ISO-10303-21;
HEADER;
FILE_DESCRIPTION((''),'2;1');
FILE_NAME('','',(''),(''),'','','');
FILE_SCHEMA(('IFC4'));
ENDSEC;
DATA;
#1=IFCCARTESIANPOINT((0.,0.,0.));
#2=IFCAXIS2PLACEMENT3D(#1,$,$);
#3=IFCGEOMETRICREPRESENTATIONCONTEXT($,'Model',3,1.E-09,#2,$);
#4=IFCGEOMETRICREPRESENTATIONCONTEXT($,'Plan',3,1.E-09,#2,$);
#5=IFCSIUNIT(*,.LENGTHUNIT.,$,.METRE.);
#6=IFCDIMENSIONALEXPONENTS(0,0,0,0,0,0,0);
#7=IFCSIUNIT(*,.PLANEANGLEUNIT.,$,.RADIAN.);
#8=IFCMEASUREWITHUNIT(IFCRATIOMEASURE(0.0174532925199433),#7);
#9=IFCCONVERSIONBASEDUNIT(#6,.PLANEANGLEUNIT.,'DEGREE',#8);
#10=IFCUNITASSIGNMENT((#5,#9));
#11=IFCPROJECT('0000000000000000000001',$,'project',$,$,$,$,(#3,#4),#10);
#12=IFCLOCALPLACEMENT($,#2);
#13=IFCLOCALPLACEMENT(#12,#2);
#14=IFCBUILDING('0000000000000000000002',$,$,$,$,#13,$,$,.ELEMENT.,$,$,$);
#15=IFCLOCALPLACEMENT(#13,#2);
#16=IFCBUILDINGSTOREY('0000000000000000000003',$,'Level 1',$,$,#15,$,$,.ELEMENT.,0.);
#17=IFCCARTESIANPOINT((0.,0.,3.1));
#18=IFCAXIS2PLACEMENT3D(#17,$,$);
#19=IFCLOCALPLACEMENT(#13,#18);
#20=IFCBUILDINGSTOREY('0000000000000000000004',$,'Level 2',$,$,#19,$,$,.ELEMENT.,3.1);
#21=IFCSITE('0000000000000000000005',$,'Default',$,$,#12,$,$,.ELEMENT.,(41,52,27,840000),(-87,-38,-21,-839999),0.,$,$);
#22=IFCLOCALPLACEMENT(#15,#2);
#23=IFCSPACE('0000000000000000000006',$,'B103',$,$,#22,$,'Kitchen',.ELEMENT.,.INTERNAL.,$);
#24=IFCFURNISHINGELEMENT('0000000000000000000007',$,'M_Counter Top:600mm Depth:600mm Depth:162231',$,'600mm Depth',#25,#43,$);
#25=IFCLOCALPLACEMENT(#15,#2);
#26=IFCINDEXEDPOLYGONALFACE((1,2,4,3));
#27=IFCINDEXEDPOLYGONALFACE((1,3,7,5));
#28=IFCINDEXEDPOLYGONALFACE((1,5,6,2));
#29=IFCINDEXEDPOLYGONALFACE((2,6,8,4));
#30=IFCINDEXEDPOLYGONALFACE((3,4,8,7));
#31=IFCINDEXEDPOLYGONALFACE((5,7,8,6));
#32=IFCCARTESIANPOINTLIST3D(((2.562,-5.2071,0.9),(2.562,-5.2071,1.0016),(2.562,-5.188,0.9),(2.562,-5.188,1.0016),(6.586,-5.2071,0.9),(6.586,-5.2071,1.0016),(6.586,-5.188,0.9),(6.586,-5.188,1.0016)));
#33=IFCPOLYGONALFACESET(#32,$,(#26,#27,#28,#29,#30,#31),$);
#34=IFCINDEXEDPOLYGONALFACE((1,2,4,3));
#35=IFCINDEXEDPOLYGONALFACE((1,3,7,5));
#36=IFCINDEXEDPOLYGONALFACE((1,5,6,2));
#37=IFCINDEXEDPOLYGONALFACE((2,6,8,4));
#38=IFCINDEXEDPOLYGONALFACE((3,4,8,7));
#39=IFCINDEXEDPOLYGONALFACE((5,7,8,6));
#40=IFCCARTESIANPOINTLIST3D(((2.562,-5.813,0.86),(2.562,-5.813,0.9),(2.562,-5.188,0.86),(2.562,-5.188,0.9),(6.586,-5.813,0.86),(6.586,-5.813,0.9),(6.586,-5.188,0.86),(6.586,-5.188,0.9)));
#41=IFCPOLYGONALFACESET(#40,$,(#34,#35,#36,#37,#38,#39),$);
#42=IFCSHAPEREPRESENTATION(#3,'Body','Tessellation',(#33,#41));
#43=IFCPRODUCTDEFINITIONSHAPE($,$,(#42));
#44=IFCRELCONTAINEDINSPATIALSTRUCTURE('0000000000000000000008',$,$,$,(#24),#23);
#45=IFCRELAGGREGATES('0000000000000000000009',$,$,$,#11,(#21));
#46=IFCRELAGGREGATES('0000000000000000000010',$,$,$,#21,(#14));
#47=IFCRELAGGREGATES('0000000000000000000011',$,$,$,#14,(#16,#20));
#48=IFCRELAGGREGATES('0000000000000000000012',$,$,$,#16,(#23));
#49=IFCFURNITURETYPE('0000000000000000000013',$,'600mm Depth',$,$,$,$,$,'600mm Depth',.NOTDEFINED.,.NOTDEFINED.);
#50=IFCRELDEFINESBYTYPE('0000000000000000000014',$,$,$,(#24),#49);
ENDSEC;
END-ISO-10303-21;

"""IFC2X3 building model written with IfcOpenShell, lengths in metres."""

from ifc_helpers import new_model, entity, si_unit, converted_unit, frame, origin, origin_2d_with_axis, place, context, project, spatial, rectangle, extrude, source, transform, mapped, type_object, type_shapes, element, save


model = new_model("IFC2X3")

# Units and contexts
model_context = context("Model", 3, precision=1e-09, world=origin())
plan_context = context("Plan", 3, precision=1e-09, world=origin())
ifc_project = project(units=[si_unit("LENGTHUNIT", "METRE"), converted_unit("PLANEANGLEUNIT", "DEGREE", entity("IfcRatioMeasure", 0.0174532925199433), si_unit("PLANEANGLEUNIT", "RADIAN"), dimensions=[0, 0, 0, 0, 0, 0, 0])], contexts=[model_context, plan_context])

# Site, building, storey
site_placement = place(None, origin())
site = spatial("IfcSite", under=ifc_project, at=site_placement, Name="Default", CompositionType="ELEMENT", RefLatitude=(41, 52, 27, 840000), RefLongitude=(-87, -38, -21, -839999), RefElevation=0.0)
building_placement = place(site_placement, origin())
building = spatial("IfcBuilding", under=site, at=building_placement, CompositionType="ELEMENT")
storey_1_placement = place(building_placement, origin())
storey_1 = spatial("IfcBuildingStorey", under=building, at=storey_1_placement, Name="Level 1", CompositionType="ELEMENT", Elevation=0.0)

# Shared definitions
storey_2_placement = place(building_placement, frame((0.0, 0.0, 3.1)))
storey_2 = spatial("IfcBuildingStorey", under=building, at=storey_2_placement, Name="Level 2", CompositionType="ELEMENT", Elevation=3.1)

# Shared definitions
space_1_placement = place(storey_1_placement, origin())
space_1 = spatial("IfcSpace", under=storey_1, at=space_1_placement, Name="B103", LongName="Kitchen", CompositionType="ELEMENT", InteriorOrExteriorSpace="INTERNAL")

# Furnishing element
furniture_type_1 = type_object("IfcFurnitureType", Name="600mm Depth", ElementType="600mm Depth", AssemblyPlace="NOTDEFINED")
shared_shape_1 = source(origin(), model_context, "Body", "SweptSolid", [
    extrude(rectangle(XDim=0.0191, YDim=4.024, at=origin_2d_with_axis()), frame((0.8115, -0.0095, 0.9), z_axis=(0.0, 0.0, 1.0), x_axis=(0.0, -1.0, 0.0)), (0.0, 0.0, 1.0), 0.1016),
    extrude(rectangle(XDim=4.024, YDim=0.625, at=origin_2d_with_axis()), frame((0.8115, -0.3125, 0.86), z_axis=(0.0, 0.0, 1.0), x_axis=(-1.0, 0.0, 0.0)), (0.0, 0.0, 1.0), 0.04),
])
type_shapes(furniture_type_1, [shared_shape_1])
furnishing_1_placement = place(space_1_placement, frame((3.7625, -5.188, 0.0)))
element("IfcFurnishingElement", 1, at=furnishing_1_placement, inside=space_1, type_object=furniture_type_1, Name="M_Counter Top:600mm Depth:600mm Depth:162231", ObjectType="600mm Depth", context=model_context, shape_type="MappedRepresentation", body=[
    mapped(shared_shape_1, transform((0.0, 0.0, 0.0), scale=1.0)),
])

save(model, "model.ifc")
